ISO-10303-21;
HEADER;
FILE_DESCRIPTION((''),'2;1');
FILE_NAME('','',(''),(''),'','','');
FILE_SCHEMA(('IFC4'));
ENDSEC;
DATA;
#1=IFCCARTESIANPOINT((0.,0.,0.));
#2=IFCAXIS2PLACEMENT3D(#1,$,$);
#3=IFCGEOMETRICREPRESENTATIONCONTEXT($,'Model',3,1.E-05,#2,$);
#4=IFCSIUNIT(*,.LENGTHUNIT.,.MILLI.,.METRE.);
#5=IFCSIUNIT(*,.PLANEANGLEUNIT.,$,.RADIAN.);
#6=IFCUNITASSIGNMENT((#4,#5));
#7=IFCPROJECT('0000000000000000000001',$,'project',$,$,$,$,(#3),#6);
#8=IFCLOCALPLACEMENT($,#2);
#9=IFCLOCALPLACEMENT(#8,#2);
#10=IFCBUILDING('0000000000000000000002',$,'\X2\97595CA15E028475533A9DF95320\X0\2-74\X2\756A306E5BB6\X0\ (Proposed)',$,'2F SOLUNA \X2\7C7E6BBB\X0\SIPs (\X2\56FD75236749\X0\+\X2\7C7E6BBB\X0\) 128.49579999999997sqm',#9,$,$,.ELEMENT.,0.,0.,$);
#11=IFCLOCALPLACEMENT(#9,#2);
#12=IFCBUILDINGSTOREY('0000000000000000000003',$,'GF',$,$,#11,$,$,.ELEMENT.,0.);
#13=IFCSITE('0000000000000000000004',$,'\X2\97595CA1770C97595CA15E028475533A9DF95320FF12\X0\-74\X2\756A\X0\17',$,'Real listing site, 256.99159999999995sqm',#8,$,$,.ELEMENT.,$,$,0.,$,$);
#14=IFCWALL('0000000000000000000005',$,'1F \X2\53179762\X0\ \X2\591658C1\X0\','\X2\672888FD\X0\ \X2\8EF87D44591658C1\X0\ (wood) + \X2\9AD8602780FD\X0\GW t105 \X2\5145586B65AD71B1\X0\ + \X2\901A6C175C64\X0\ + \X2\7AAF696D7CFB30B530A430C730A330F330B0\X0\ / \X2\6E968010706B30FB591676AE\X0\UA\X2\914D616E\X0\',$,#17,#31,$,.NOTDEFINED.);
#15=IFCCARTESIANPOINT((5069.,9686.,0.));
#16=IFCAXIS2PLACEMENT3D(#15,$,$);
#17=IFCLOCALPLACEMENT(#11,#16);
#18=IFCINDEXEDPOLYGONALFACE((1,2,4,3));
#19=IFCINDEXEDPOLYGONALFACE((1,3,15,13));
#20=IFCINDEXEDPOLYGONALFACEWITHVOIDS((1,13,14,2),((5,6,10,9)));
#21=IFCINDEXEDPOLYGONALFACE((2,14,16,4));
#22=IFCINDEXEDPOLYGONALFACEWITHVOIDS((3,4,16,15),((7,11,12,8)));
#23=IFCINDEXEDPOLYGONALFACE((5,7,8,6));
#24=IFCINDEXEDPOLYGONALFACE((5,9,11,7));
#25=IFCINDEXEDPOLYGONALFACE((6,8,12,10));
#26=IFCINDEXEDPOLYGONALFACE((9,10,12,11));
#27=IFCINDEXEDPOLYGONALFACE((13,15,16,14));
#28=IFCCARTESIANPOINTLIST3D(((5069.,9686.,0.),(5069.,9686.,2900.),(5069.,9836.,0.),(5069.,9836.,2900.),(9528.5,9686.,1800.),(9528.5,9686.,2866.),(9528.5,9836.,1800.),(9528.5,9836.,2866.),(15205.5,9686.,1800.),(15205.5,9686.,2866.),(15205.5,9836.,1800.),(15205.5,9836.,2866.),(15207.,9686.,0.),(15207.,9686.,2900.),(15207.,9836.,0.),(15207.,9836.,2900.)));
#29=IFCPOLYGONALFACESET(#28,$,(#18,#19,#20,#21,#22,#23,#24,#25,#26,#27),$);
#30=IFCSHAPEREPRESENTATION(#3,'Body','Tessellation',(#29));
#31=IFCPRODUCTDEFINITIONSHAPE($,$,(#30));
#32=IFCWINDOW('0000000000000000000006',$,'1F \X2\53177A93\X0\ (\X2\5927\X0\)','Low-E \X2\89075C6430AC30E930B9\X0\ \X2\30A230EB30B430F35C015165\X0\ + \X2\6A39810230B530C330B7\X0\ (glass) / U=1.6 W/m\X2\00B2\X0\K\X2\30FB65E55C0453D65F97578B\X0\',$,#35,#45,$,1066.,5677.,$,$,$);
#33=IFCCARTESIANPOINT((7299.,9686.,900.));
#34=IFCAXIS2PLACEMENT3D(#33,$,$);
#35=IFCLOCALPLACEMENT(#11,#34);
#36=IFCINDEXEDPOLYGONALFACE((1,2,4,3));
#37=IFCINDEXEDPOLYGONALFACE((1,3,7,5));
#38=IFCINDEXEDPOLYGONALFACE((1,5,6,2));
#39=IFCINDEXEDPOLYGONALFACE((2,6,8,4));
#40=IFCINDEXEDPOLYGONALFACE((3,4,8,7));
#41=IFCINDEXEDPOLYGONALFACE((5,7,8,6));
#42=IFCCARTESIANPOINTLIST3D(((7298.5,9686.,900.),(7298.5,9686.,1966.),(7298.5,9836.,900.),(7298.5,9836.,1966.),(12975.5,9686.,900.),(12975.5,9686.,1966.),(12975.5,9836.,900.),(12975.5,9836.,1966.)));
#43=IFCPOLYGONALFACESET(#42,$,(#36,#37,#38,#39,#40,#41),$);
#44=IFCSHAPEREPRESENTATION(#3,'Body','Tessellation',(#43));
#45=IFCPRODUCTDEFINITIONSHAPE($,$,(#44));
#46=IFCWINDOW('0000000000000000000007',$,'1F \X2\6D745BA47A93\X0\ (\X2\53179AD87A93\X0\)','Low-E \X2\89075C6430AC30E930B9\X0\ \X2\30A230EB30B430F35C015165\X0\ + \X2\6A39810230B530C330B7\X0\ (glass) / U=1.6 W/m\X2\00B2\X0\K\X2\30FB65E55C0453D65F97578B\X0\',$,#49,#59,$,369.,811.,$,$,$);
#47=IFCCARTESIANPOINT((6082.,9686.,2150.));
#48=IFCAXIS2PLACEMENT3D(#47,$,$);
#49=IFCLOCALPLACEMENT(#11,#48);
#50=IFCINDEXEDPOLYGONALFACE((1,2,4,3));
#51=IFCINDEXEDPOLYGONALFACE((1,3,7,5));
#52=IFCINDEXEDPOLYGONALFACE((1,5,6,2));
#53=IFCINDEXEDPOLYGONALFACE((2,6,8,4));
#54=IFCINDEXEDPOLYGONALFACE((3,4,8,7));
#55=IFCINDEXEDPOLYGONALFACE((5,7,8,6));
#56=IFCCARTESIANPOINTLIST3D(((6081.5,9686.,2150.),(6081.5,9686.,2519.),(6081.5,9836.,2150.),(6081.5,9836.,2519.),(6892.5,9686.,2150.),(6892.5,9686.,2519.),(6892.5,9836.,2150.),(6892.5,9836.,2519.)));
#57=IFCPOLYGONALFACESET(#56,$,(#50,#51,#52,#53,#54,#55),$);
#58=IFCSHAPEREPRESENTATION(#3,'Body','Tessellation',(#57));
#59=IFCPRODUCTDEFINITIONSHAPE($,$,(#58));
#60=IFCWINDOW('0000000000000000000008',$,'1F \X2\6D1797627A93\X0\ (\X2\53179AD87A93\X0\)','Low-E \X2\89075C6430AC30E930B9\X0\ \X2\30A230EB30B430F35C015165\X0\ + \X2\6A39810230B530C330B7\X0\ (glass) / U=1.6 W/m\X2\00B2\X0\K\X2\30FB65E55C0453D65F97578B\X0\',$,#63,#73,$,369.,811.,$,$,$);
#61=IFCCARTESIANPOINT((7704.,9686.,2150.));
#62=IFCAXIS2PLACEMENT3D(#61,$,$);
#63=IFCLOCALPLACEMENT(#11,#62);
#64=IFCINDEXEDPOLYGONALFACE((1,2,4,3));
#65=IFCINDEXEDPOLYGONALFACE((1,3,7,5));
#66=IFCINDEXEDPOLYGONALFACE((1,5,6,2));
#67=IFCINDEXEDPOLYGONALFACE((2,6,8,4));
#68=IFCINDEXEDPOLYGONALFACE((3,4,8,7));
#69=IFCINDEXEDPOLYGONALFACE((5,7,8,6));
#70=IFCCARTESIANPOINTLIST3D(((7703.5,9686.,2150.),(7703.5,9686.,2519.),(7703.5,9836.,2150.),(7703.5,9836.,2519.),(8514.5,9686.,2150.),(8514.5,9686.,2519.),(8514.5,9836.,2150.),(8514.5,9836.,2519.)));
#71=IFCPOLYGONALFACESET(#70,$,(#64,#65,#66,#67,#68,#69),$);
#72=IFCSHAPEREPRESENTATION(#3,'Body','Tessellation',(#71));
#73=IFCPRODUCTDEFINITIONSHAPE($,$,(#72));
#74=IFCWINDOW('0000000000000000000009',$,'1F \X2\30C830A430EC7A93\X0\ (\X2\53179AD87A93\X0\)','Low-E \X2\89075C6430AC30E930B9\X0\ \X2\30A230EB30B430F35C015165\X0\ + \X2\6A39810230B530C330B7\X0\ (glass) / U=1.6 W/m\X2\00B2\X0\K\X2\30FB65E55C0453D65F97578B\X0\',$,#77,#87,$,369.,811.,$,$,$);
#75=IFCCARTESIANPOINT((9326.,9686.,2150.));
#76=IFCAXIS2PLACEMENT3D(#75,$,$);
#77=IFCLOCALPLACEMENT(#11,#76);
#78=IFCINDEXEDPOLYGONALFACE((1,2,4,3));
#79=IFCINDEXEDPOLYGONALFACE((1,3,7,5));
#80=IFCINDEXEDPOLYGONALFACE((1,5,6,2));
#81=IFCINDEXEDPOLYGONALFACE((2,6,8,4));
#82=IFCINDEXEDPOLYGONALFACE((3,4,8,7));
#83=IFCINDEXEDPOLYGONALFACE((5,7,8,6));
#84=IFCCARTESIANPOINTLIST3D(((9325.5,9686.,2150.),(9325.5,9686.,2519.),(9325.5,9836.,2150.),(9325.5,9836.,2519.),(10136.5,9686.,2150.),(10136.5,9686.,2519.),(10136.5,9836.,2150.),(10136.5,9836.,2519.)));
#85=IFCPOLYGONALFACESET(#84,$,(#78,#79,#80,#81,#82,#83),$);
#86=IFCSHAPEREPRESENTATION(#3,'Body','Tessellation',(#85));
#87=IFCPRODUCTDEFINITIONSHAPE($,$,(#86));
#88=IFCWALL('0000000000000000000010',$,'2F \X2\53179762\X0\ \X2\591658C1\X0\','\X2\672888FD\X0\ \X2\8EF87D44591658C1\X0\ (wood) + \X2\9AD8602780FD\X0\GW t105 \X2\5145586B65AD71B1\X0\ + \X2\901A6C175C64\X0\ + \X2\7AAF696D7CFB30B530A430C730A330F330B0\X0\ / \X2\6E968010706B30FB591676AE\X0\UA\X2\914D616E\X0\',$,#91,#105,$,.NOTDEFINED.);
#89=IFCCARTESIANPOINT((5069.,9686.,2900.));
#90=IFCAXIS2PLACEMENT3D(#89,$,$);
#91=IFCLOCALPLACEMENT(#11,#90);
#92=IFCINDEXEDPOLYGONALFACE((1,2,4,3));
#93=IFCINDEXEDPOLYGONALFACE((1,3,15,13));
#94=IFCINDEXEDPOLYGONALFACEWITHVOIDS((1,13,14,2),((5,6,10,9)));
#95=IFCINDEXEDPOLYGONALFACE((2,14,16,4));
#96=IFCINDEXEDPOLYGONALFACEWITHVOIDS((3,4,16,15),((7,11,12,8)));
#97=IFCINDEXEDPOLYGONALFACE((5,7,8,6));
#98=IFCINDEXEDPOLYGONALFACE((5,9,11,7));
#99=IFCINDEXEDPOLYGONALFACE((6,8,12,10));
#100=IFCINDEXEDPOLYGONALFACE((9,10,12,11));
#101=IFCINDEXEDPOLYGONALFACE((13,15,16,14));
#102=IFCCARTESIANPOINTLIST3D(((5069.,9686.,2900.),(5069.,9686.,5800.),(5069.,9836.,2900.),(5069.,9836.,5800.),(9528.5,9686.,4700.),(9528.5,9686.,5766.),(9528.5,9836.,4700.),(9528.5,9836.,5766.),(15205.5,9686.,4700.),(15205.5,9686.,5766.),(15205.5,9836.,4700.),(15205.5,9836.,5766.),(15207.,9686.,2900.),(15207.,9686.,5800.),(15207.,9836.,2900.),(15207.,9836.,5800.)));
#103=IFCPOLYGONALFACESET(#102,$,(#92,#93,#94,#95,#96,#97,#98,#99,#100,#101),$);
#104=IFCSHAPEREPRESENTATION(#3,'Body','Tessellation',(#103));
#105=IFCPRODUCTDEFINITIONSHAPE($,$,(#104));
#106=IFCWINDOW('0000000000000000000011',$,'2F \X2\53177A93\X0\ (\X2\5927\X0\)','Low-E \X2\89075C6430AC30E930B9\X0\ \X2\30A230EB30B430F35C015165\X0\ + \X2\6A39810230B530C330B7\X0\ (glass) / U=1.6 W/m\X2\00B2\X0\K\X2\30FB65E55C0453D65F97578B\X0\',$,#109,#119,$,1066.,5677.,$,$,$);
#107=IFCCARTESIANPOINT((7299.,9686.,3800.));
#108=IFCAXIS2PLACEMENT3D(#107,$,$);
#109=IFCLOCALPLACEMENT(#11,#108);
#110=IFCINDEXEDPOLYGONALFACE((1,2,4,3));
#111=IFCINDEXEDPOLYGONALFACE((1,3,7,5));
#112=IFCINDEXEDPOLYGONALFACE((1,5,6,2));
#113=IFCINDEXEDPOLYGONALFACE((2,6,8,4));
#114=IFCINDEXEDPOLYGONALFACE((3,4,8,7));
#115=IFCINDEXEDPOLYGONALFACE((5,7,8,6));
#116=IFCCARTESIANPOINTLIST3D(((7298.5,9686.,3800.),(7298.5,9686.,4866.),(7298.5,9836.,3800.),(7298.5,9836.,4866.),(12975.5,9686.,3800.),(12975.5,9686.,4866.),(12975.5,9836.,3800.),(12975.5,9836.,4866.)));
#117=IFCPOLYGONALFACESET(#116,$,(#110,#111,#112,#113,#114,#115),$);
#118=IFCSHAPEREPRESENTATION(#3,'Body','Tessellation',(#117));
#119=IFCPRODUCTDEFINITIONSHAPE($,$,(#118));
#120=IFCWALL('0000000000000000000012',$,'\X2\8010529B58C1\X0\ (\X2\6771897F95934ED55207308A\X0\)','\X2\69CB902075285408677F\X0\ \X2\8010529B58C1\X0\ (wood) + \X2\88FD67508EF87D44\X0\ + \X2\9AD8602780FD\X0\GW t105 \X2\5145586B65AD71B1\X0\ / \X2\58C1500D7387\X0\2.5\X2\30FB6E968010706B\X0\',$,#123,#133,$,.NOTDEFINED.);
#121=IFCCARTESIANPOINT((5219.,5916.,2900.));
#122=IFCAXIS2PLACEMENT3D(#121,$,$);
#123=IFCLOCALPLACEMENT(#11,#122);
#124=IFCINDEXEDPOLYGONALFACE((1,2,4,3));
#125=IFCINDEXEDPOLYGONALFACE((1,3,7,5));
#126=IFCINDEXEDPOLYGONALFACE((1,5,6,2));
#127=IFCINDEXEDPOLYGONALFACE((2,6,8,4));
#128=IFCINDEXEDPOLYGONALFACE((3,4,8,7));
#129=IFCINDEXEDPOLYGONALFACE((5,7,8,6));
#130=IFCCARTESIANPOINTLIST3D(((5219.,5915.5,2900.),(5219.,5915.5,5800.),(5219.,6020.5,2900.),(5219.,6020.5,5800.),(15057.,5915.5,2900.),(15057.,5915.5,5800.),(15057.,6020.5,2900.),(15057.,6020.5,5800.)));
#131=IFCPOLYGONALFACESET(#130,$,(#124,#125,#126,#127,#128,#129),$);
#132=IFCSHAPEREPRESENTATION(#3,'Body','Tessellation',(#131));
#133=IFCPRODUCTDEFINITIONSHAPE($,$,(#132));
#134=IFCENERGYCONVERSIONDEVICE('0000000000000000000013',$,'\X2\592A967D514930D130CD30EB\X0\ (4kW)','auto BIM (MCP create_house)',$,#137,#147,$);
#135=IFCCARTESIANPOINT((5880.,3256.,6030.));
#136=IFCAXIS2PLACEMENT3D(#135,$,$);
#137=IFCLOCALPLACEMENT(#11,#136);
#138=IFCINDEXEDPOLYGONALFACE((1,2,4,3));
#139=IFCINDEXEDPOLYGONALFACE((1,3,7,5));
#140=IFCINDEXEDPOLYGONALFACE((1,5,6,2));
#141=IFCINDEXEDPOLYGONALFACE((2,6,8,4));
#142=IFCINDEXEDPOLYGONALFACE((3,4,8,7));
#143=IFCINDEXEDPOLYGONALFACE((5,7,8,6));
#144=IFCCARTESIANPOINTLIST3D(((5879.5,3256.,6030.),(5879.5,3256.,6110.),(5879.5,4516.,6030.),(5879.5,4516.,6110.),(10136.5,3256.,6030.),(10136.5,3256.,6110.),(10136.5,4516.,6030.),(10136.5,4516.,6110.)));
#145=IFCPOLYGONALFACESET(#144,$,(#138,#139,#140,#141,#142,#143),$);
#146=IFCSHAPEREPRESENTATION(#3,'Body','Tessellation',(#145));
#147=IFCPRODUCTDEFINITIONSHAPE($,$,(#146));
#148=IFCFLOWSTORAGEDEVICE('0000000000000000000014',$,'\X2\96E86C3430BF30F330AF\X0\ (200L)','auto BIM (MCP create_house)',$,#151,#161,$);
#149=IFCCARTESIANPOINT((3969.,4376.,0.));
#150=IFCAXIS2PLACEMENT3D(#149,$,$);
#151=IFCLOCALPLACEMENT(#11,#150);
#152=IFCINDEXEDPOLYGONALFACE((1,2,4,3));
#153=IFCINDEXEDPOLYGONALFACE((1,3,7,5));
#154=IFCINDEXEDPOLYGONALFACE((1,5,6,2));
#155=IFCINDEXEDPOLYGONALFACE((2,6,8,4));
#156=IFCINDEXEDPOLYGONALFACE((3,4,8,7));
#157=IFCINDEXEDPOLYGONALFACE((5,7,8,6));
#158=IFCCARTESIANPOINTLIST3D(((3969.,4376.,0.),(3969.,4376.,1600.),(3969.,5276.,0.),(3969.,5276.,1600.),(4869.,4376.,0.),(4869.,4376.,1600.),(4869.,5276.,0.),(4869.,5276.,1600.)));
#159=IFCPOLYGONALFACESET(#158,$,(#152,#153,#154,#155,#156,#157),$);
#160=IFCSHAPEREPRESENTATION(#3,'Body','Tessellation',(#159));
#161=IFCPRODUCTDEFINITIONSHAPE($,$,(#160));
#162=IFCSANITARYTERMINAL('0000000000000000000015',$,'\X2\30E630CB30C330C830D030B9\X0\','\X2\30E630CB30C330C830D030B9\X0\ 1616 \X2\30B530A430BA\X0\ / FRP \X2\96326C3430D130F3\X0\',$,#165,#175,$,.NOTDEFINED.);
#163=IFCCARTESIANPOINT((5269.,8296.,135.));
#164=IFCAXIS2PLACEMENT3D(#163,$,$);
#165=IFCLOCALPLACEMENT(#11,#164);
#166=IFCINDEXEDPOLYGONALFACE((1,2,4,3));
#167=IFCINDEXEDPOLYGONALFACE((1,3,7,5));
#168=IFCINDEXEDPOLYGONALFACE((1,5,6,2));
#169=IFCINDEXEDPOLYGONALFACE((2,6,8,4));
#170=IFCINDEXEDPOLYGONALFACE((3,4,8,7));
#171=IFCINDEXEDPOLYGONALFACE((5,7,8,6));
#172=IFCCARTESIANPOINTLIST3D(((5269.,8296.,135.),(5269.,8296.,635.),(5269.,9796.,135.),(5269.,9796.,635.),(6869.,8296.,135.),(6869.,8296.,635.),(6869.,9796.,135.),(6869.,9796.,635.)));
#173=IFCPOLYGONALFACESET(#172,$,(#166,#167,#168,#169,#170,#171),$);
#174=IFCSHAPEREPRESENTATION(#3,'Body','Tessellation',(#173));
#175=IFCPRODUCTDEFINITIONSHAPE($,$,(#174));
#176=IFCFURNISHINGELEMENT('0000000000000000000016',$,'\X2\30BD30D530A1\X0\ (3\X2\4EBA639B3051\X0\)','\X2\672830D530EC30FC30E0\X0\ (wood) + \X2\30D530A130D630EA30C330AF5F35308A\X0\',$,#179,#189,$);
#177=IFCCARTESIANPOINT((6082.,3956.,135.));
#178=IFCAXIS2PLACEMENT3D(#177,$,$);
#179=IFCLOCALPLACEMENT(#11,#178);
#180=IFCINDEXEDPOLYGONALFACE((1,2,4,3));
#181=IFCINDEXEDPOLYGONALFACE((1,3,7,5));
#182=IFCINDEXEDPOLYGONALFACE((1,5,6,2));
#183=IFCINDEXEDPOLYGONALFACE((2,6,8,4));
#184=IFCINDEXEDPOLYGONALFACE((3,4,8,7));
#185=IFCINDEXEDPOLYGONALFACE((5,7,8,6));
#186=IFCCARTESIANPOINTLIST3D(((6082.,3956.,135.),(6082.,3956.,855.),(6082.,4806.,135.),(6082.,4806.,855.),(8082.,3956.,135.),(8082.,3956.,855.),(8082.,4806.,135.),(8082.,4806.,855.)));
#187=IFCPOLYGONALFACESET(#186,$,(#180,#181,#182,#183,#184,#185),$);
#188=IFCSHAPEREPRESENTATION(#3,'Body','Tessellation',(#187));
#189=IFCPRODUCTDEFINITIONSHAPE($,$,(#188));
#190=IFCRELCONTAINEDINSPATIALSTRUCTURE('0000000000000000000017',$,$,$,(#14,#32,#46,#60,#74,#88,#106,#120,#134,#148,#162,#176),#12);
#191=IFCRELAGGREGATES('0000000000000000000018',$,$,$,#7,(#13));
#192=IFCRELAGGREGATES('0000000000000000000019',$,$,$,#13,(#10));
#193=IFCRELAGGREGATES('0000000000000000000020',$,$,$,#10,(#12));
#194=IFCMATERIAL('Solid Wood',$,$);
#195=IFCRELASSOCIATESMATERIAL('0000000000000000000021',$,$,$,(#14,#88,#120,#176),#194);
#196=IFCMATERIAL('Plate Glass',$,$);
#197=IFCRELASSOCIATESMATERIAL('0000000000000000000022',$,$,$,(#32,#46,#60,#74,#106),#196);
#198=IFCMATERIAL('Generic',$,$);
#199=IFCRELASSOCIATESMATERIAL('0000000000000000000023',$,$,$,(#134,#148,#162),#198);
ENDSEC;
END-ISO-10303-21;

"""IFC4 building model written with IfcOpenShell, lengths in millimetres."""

from ifc_helpers import new_model, si_unit, frame, frame_2d, origin, place, context, project, spatial, rectangle, extrude, material, element, fill, save


model = new_model("IFC4")

# Units and contexts
model_context = context("Model", 3, precision=1e-05, world=origin())
ifc_project = project(units=[si_unit("LENGTHUNIT", "METRE", prefix="MILLI"), si_unit("PLANEANGLEUNIT", "RADIAN")], contexts=[model_context])

# Site, building, storey
site_placement = place(None, origin())
site = spatial("IfcSite", under=ifc_project, at=site_placement, Name="静岡県静岡市葵区鷹匠２-74番17", ObjectType="Real listing site, 256.99159999999995sqm", CompositionType="ELEMENT", RefElevation=0.0)
building_placement = place(site_placement, origin())
building = spatial("IfcBuilding", under=site, at=building_placement, Name="静岡市葵区鷹匠2-74番の家 (Proposed)", ObjectType="2F SOLUNA 籾殻SIPs (国産杉+籾殻) 128.49579999999997sqm", CompositionType="ELEMENT", ElevationOfRefHeight=0.0, ElevationOfTerrain=0.0)
storey_placement = place(building_placement, origin())
storey = spatial("IfcBuildingStorey", under=building, at=storey_placement, Name="GF", CompositionType="ELEMENT", Elevation=0.0)

# Wall, openings, windows
ifc_material_1 = material(Name="Solid Wood")
wall_1_placement = place(storey_placement, frame((5069.0, 9686.0, 0.0)))
wall_1 = element("IfcWall", 1, at=wall_1_placement, inside=storey, material=ifc_material_1, Name="1F 北面 外壁", Description="木製 軸組外壁 (wood) + 高性能GW t105 充填断熱 + 通気層 + 窯業系サイディング / 準耐火・外皮UA配慮", PredefinedType="NOTDEFINED", context=model_context, shape_type="SweptSolid", body=[
    extrude(rectangle(XDim=10138.0, YDim=150.0, at=frame_2d((5069.0, 75.0))), frame((5069.0, 9686.0, 0.0)), (0.0, 0.0, 1.0), 2900.0),
])
opening_1_placement = place(storey_placement, frame((7299.0, 9686.0, 900.0)))
opening_1 = element("IfcOpeningElement", 2, at=opening_1_placement, cuts=wall_1, PredefinedType="NOTDEFINED", context=model_context, shape_type="SweptSolid", body=[
    extrude(rectangle(XDim=5677.0, YDim=150.0, at=frame_2d((2838.0, 75.0))), frame((7299.0, 9686.0, 900.0)), (0.0, 0.0, 1.0), 1066.0),
])
opening_2_placement = place(storey_placement, frame((6082.0, 9686.0, 2150.0)))
opening_2 = element("IfcOpeningElement", 3, at=opening_2_placement, cuts=wall_1, PredefinedType="NOTDEFINED", context=model_context, shape_type="SweptSolid", body=[
    extrude(rectangle(XDim=811.0, YDim=150.0, at=frame_2d((405.0, 75.0))), frame((6082.0, 9686.0, 2150.0)), (0.0, 0.0, 1.0), 369.0),
])
opening_3_placement = place(storey_placement, frame((7704.0, 9686.0, 2150.0)))
opening_3 = element("IfcOpeningElement", 4, at=opening_3_placement, cuts=wall_1, PredefinedType="NOTDEFINED", context=model_context, shape_type="SweptSolid", body=[
    extrude(rectangle(XDim=811.0, YDim=150.0, at=frame_2d((405.0, 75.0))), frame((7704.0, 9686.0, 2150.0)), (0.0, 0.0, 1.0), 369.0),
])
opening_4_placement = place(storey_placement, frame((9326.0, 9686.0, 2150.0)))
opening_4 = element("IfcOpeningElement", 5, at=opening_4_placement, cuts=wall_1, PredefinedType="NOTDEFINED", context=model_context, shape_type="SweptSolid", body=[
    extrude(rectangle(XDim=811.0, YDim=150.0, at=frame_2d((405.0, 75.0))), frame((9326.0, 9686.0, 2150.0)), (0.0, 0.0, 1.0), 369.0),
])
ifc_material_2 = material(Name="Plate Glass")
window_1_placement = place(storey_placement, frame((7299.0, 9686.0, 900.0)))
window_1 = element("IfcWindow", 6, at=window_1_placement, inside=storey, material=ifc_material_2, Name="1F 北窓 (大)", Description="Low-E 複層ガラス アルゴン封入 + 樹脂サッシ (glass) / U=1.6 W/m²K・日射取得型", OverallHeight=1066.0, OverallWidth=5677.0, context=model_context, shape_type="SweptSolid", body=[
    extrude(rectangle(XDim=5677.0, YDim=150.0, at=frame_2d((2838.0, 75.0))), frame((7299.0, 9686.0, 900.0)), (0.0, 0.0, 1.0), 1066.0),
])
fill(opening_1, window_1)
window_2_placement = place(storey_placement, frame((6082.0, 9686.0, 2150.0)))
window_2 = element("IfcWindow", 7, at=window_2_placement, inside=storey, material=ifc_material_2, Name="1F 浴室窓 (北高窓)", Description="Low-E 複層ガラス アルゴン封入 + 樹脂サッシ (glass) / U=1.6 W/m²K・日射取得型", OverallHeight=369.0, OverallWidth=811.0, context=model_context, shape_type="SweptSolid", body=[
    extrude(rectangle(XDim=811.0, YDim=150.0, at=frame_2d((405.0, 75.0))), frame((6082.0, 9686.0, 2150.0)), (0.0, 0.0, 1.0), 369.0),
])
fill(opening_2, window_2)
window_3_placement = place(storey_placement, frame((7704.0, 9686.0, 2150.0)))
window_3 = element("IfcWindow", 8, at=window_3_placement, inside=storey, material=ifc_material_2, Name="1F 洗面窓 (北高窓)", Description="Low-E 複層ガラス アルゴン封入 + 樹脂サッシ (glass) / U=1.6 W/m²K・日射取得型", OverallHeight=369.0, OverallWidth=811.0, context=model_context, shape_type="SweptSolid", body=[
    extrude(rectangle(XDim=811.0, YDim=150.0, at=frame_2d((405.0, 75.0))), frame((7704.0, 9686.0, 2150.0)), (0.0, 0.0, 1.0), 369.0),
])
fill(opening_3, window_3)
window_4_placement = place(storey_placement, frame((9326.0, 9686.0, 2150.0)))
window_4 = element("IfcWindow", 9, at=window_4_placement, inside=storey, material=ifc_material_2, Name="1F トイレ窓 (北高窓)", Description="Low-E 複層ガラス アルゴン封入 + 樹脂サッシ (glass) / U=1.6 W/m²K・日射取得型", OverallHeight=369.0, OverallWidth=811.0, context=model_context, shape_type="SweptSolid", body=[
    extrude(rectangle(XDim=811.0, YDim=150.0, at=frame_2d((405.0, 75.0))), frame((9326.0, 9686.0, 2150.0)), (0.0, 0.0, 1.0), 369.0),
])
fill(opening_4, window_4)

# Wall, opening, window
wall_2_placement = place(storey_placement, frame((5069.0, 9686.0, 2900.0)))
wall_2 = element("IfcWall", 10, at=wall_2_placement, inside=storey, material=ifc_material_1, Name="2F 北面 外壁", Description="木製 軸組外壁 (wood) + 高性能GW t105 充填断熱 + 通気層 + 窯業系サイディング / 準耐火・外皮UA配慮", PredefinedType="NOTDEFINED", context=model_context, shape_type="SweptSolid", body=[
    extrude(rectangle(XDim=10138.0, YDim=150.0, at=frame_2d((5069.0, 75.0))), frame((5069.0, 9686.0, 2900.0)), (0.0, 0.0, 1.0), 2900.0),
])
opening_5_placement = place(storey_placement, frame((7299.0, 9686.0, 3800.0)))
opening_5 = element("IfcOpeningElement", 11, at=opening_5_placement, cuts=wall_2, PredefinedType="NOTDEFINED", context=model_context, shape_type="SweptSolid", body=[
    extrude(rectangle(XDim=5677.0, YDim=150.0, at=frame_2d((2838.0, 75.0))), frame((7299.0, 9686.0, 3800.0)), (0.0, 0.0, 1.0), 1066.0),
])
window_5_placement = place(storey_placement, frame((7299.0, 9686.0, 3800.0)))
window_5 = element("IfcWindow", 12, at=window_5_placement, inside=storey, material=ifc_material_2, Name="2F 北窓 (大)", Description="Low-E 複層ガラス アルゴン封入 + 樹脂サッシ (glass) / U=1.6 W/m²K・日射取得型", OverallHeight=1066.0, OverallWidth=5677.0, context=model_context, shape_type="SweptSolid", body=[
    extrude(rectangle(XDim=5677.0, YDim=150.0, at=frame_2d((2838.0, 75.0))), frame((7299.0, 9686.0, 3800.0)), (0.0, 0.0, 1.0), 1066.0),
])
fill(opening_5, window_5)

# Wall
wall_3_placement = place(storey_placement, frame((5219.0, 5916.0, 2900.0)))
element("IfcWall", 13, at=wall_3_placement, inside=storey, material=ifc_material_1, Name="耐力壁 (東西間仕切り)", Description="構造用合板 耐力壁 (wood) + 製材軸組 + 高性能GW t105 充填断熱 / 壁倍率2.5・準耐火", PredefinedType="NOTDEFINED", context=model_context, shape_type="SweptSolid", body=[
    extrude(rectangle(XDim=9838.0, YDim=105.0, at=frame_2d((4919.0, 52.0))), frame((5219.0, 5916.0, 2900.0)), (0.0, 0.0, 1.0), 2900.0),
])

# Energy conversion device
ifc_material_3 = material(Name="Generic")
energy_conversion_device_placement = place(storey_placement, frame((5880.0, 3256.0, 6030.0)))
element("IfcEnergyConversionDevice", 14, at=energy_conversion_device_placement, inside=storey, material=ifc_material_3, Name="太陽光パネル (4kW)", Description="auto BIM (MCP create_house)", context=model_context, shape_type="SweptSolid", body=[
    extrude(rectangle(XDim=4257.0, YDim=1260.0, at=frame_2d((2128.0, 630.0))), frame((5880.0, 3256.0, 6030.0)), (0.0, 0.0, 1.0), 80.0),
])

# Flow storage device
flow_storage_device_placement = place(storey_placement, frame((3969.0, 4376.0, 0.0)))
element("IfcFlowStorageDevice", 15, at=flow_storage_device_placement, inside=storey, material=ifc_material_3, Name="雨水タンク (200L)", Description="auto BIM (MCP create_house)", context=model_context, shape_type="SweptSolid", body=[
    extrude(rectangle(XDim=900.0, YDim=900.0, at=frame_2d((450.0, 450.0))), frame((3969.0, 4376.0, 0.0)), (0.0, 0.0, 1.0), 1600.0),
])

# Sanitary terminal
sanitary_terminal_placement = place(storey_placement, frame((5269.0, 8296.0, 135.0)))
element("IfcSanitaryTerminal", 16, at=sanitary_terminal_placement, inside=storey, material=ifc_material_3, Name="ユニットバス", Description="ユニットバス 1616 サイズ / FRP 防水パン", PredefinedType="NOTDEFINED", context=model_context, shape_type="SweptSolid", body=[
    extrude(rectangle(XDim=1600.0, YDim=1500.0, at=frame_2d((800.0, 750.0))), frame((5269.0, 8296.0, 135.0)), (0.0, 0.0, 1.0), 500.0),
])

# Furnishing element
furnishing_1_placement = place(storey_placement, frame((6082.0, 3956.0, 135.0)))
element("IfcFurnishingElement", 17, at=furnishing_1_placement, inside=storey, material=ifc_material_1, Name="ソファ (3人掛け)", Description="木フレーム (wood) + ファブリック張り", context=model_context, shape_type="SweptSolid", body=[
    extrude(rectangle(XDim=2000.0, YDim=850.0, at=frame_2d((1000.0, 425.0))), frame((6082.0, 3956.0, 135.0)), (0.0, 0.0, 1.0), 720.0),
])

save(model, "model.ifc")
